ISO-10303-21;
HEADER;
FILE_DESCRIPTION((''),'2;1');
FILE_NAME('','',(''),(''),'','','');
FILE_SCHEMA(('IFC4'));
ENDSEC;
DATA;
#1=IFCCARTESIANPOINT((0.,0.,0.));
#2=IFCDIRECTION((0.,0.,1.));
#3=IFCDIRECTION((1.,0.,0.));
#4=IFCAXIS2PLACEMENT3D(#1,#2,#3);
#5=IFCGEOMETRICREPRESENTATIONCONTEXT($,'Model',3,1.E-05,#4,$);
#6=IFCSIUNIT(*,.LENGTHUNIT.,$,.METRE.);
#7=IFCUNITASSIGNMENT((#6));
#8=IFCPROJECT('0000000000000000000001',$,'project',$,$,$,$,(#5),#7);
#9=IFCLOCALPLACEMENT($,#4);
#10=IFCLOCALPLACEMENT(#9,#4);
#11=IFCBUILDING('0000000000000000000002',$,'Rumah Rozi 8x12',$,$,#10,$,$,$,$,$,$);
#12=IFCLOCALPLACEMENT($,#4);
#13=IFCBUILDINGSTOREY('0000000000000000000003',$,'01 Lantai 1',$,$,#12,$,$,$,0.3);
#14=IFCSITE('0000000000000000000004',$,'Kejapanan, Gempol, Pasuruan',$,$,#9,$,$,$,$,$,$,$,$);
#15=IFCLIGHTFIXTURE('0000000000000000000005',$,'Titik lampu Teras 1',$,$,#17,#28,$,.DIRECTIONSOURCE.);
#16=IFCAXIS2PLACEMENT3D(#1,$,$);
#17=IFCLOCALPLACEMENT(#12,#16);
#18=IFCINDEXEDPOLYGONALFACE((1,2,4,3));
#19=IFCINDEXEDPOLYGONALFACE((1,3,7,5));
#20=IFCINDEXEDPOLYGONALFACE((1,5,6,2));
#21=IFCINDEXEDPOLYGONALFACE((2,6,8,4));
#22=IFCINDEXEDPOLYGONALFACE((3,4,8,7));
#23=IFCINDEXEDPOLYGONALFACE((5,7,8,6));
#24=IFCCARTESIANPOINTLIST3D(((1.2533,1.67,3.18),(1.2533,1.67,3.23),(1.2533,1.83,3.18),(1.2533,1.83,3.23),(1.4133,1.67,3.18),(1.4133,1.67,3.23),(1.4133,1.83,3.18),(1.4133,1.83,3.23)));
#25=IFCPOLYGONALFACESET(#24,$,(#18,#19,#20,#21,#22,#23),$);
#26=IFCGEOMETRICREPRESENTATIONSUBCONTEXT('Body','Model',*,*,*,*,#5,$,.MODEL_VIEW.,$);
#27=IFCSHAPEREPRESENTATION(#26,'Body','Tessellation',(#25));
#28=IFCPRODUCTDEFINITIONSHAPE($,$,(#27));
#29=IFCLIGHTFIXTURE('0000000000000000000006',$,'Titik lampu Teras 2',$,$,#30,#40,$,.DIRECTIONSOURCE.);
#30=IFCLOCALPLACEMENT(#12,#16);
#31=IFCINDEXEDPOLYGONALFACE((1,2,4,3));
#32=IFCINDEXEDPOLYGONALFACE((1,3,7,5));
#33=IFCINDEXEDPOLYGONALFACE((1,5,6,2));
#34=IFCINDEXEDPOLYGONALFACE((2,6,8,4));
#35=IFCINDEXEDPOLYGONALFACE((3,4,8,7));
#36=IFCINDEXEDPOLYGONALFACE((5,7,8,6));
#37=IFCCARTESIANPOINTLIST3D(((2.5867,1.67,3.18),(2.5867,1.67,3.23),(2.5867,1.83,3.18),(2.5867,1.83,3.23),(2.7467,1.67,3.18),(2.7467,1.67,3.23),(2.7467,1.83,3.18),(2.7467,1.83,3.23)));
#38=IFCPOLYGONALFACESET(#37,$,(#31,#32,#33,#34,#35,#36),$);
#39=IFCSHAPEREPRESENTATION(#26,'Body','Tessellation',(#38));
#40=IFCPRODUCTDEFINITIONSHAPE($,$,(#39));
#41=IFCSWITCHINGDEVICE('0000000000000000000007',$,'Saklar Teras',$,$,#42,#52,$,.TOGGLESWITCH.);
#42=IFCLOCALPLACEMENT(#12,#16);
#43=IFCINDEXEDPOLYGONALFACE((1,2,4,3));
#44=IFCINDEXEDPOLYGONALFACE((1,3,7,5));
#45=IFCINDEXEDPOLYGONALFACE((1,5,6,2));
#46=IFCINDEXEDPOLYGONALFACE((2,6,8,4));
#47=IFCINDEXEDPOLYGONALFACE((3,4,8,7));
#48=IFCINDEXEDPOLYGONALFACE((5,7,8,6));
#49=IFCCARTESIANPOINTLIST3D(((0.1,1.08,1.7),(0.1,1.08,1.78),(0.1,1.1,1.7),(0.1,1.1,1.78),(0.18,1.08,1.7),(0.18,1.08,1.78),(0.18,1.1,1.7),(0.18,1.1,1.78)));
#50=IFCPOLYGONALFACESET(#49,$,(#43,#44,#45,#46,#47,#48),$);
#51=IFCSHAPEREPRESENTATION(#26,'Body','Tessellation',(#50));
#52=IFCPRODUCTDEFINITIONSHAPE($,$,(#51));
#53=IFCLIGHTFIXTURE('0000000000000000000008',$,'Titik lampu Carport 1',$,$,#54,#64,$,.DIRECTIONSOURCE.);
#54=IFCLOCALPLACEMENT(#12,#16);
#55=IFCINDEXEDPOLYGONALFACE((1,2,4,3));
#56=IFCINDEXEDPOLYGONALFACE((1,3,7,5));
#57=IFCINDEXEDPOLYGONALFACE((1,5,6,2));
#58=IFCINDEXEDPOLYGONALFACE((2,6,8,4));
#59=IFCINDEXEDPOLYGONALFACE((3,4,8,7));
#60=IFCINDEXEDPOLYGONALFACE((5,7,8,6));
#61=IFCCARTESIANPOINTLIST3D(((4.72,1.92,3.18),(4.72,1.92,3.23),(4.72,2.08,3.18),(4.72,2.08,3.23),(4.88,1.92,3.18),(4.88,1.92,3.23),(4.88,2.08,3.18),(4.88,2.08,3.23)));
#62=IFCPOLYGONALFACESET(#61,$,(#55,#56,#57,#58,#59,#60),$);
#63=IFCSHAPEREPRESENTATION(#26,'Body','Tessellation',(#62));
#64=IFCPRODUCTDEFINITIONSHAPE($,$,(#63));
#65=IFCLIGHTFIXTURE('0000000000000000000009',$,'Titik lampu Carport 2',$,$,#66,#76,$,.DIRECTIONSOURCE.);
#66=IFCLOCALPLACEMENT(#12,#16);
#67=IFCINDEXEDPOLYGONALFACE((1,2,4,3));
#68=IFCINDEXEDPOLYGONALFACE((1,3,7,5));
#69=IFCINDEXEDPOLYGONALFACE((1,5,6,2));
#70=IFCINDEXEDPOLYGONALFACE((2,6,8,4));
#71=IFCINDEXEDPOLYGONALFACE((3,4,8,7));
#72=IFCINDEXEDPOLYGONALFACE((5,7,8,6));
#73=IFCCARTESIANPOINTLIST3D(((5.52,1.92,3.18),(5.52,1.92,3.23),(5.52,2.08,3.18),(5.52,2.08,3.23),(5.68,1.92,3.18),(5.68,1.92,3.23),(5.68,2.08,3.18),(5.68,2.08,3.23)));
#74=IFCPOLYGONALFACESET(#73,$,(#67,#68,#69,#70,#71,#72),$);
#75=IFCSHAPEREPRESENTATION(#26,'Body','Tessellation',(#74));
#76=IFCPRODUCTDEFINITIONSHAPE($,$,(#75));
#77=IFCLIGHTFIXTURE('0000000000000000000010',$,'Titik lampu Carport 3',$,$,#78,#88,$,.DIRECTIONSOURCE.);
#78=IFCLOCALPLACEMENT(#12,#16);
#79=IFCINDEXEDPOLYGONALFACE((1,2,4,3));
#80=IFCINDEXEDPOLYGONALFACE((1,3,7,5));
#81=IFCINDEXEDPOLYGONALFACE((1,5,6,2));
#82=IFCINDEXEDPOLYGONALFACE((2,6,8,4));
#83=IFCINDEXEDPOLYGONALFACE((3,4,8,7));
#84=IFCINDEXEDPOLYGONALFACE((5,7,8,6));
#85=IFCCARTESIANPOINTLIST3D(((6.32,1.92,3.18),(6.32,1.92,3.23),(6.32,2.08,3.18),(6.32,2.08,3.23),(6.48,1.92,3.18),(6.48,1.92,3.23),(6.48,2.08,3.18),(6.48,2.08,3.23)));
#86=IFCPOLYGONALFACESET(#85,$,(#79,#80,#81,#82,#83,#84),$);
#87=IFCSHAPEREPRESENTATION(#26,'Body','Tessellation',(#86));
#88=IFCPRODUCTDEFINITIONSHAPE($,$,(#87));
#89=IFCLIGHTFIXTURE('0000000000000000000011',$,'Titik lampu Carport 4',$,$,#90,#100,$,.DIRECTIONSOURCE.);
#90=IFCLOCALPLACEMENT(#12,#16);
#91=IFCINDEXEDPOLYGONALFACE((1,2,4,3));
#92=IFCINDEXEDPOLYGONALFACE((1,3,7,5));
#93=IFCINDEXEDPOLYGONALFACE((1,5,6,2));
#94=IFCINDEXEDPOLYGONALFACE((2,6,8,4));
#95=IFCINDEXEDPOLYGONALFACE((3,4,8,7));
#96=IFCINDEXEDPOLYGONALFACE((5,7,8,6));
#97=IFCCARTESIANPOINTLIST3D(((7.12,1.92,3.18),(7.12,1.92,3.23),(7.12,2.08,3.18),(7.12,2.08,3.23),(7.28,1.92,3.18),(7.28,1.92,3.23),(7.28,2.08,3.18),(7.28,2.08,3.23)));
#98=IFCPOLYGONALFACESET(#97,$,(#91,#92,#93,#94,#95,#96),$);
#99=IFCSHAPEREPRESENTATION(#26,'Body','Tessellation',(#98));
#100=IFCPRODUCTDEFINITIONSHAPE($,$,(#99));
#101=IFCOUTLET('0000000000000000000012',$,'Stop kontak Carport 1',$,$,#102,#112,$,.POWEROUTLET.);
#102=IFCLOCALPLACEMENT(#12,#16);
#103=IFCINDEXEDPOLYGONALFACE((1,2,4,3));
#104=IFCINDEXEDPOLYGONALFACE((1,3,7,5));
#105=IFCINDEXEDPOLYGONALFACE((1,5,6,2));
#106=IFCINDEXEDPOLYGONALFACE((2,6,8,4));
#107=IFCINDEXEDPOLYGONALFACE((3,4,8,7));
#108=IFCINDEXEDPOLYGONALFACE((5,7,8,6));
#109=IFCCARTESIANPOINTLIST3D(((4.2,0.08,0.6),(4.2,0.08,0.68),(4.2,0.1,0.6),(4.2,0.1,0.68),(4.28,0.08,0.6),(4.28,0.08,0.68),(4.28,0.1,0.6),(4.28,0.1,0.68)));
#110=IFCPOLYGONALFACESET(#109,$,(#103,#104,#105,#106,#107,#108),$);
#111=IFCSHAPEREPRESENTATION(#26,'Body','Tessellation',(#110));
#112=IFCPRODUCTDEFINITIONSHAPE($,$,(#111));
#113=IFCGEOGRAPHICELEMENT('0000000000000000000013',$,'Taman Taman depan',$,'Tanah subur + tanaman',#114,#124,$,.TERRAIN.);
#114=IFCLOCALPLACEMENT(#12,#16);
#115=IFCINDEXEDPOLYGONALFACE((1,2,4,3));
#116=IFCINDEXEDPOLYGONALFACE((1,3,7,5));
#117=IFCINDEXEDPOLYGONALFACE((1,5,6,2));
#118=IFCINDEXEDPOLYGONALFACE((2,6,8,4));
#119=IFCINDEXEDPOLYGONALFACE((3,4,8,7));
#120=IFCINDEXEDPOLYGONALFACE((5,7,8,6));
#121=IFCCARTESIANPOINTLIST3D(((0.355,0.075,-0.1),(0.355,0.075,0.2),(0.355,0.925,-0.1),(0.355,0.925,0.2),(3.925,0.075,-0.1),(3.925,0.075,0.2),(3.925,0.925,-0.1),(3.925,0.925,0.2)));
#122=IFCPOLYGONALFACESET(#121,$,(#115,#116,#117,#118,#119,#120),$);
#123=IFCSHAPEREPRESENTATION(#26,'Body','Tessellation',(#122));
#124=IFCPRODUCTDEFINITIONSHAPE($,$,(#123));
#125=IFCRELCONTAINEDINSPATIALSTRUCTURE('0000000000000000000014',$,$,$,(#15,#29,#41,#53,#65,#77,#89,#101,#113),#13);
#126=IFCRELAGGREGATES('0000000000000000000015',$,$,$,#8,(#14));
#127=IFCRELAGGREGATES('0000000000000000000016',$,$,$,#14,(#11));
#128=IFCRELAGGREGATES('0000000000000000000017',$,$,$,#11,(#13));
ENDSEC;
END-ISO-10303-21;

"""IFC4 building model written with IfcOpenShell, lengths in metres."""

from ifc_helpers import new_model, si_unit, frame, origin_with_axes, place, context, subcontext, project, spatial, line, indexed_curve, outline, extrude, element, save


model = new_model("IFC4")

# Units and contexts
model_context = context("Model", 3, precision=1e-05, world=origin_with_axes())
body_context = subcontext(model_context, "Body", "Model", "MODEL_VIEW")
ifc_project = project(units=[si_unit("LENGTHUNIT", "METRE")], contexts=[model_context])

# Site, building, storey
site_placement = place(None, origin_with_axes())
site = spatial("IfcSite", under=ifc_project, at=site_placement, Name="Kejapanan, Gempol, Pasuruan")
building_placement = place(site_placement, origin_with_axes())
building = spatial("IfcBuilding", under=site, at=building_placement, Name="Rumah Rozi 8x12")
storey_placement = place(None, origin_with_axes())
storey = spatial("IfcBuildingStorey", under=building, at=storey_placement, Name="01 Lantai 1", Elevation=0.3)

# Light fixtures
light_fixture_1_placement = place(storey_placement, origin_with_axes())
element("IfcLightFixture", 1, at=light_fixture_1_placement, inside=storey, Name="Titik lampu Teras 1", PredefinedType="DIRECTIONSOURCE", context=body_context, shape_type="SweptSolid", body=[
    extrude(outline(indexed_curve([(1.2533, 1.67), (1.4133, 1.67), (1.4133, 1.83), (1.2533, 1.83)], segments=[line(1, 2, 3, 4, 1)])), frame((0.0, 0.0, 3.18), z_axis=(0.0, 0.0, 1.0), x_axis=(1.0, 0.0, 0.0)), (0.0, 0.0, 1.0), 0.05),
])
light_fixture_2_placement = place(storey_placement, origin_with_axes())
element("IfcLightFixture", 2, at=light_fixture_2_placement, inside=storey, Name="Titik lampu Teras 2", PredefinedType="DIRECTIONSOURCE", context=body_context, shape_type="SweptSolid", body=[
    extrude(outline(indexed_curve([(2.5867, 1.67), (2.7467, 1.67), (2.7467, 1.83), (2.5867, 1.83)], segments=[line(1, 2, 3, 4, 1)])), frame((0.0, 0.0, 3.18), z_axis=(0.0, 0.0, 1.0), x_axis=(1.0, 0.0, 0.0)), (0.0, 0.0, 1.0), 0.05),
])

# Switching device
switching_device_placement = place(storey_placement, origin_with_axes())
element("IfcSwitchingDevice", 3, at=switching_device_placement, inside=storey, Name="Saklar Teras", PredefinedType="TOGGLESWITCH", context=body_context, shape_type="SweptSolid", body=[
    extrude(outline(indexed_curve([(0.1, 1.08), (0.18, 1.08), (0.18, 1.1), (0.1, 1.1)], segments=[line(1, 2, 3, 4, 1)])), frame((0.0, 0.0, 1.7), z_axis=(0.0, 0.0, 1.0), x_axis=(1.0, 0.0, 0.0)), (0.0, 0.0, 1.0), 0.08),
])

# Light fixtures
light_fixture_3_placement = place(storey_placement, origin_with_axes())
element("IfcLightFixture", 4, at=light_fixture_3_placement, inside=storey, Name="Titik lampu Carport 1", PredefinedType="DIRECTIONSOURCE", context=body_context, shape_type="SweptSolid", body=[
    extrude(outline(indexed_curve([(4.72, 1.92), (4.88, 1.92), (4.88, 2.08), (4.72, 2.08)], segments=[line(1, 2, 3, 4, 1)])), frame((0.0, 0.0, 3.18), z_axis=(0.0, 0.0, 1.0), x_axis=(1.0, 0.0, 0.0)), (0.0, 0.0, 1.0), 0.05),
])
light_fixture_4_placement = place(storey_placement, origin_with_axes())
element("IfcLightFixture", 5, at=light_fixture_4_placement, inside=storey, Name="Titik lampu Carport 2", PredefinedType="DIRECTIONSOURCE", context=body_context, shape_type="SweptSolid", body=[
    extrude(outline(indexed_curve([(5.52, 1.92), (5.68, 1.92), (5.68, 2.08), (5.52, 2.08)], segments=[line(1, 2, 3, 4, 1)])), frame((0.0, 0.0, 3.18), z_axis=(0.0, 0.0, 1.0), x_axis=(1.0, 0.0, 0.0)), (0.0, 0.0, 1.0), 0.05),
])
light_fixture_5_placement = place(storey_placement, origin_with_axes())
element("IfcLightFixture", 6, at=light_fixture_5_placement, inside=storey, Name="Titik lampu Carport 3", PredefinedType="DIRECTIONSOURCE", context=body_context, shape_type="SweptSolid", body=[
    extrude(outline(indexed_curve([(6.32, 1.92), (6.48, 1.92), (6.48, 2.08), (6.32, 2.08)], segments=[line(1, 2, 3, 4, 1)])), frame((0.0, 0.0, 3.18), z_axis=(0.0, 0.0, 1.0), x_axis=(1.0, 0.0, 0.0)), (0.0, 0.0, 1.0), 0.05),
])
light_fixture_6_placement = place(storey_placement, origin_with_axes())
element("IfcLightFixture", 7, at=light_fixture_6_placement, inside=storey, Name="Titik lampu Carport 4", PredefinedType="DIRECTIONSOURCE", context=body_context, shape_type="SweptSolid", body=[
    extrude(outline(indexed_curve([(7.12, 1.92), (7.28, 1.92), (7.28, 2.08), (7.12, 2.08)], segments=[line(1, 2, 3, 4, 1)])), frame((0.0, 0.0, 3.18), z_axis=(0.0, 0.0, 1.0), x_axis=(1.0, 0.0, 0.0)), (0.0, 0.0, 1.0), 0.05),
])

# Outlet
outlet_placement = place(storey_placement, origin_with_axes())
element("IfcOutlet", 8, at=outlet_placement, inside=storey, Name="Stop kontak Carport 1", PredefinedType="POWEROUTLET", context=body_context, shape_type="SweptSolid", body=[
    extrude(outline(indexed_curve([(4.2, 0.08), (4.28, 0.08), (4.28, 0.1), (4.2, 0.1)], segments=[line(1, 2, 3, 4, 1)])), frame((0.0, 0.0, 0.6), z_axis=(0.0, 0.0, 1.0), x_axis=(1.0, 0.0, 0.0)), (0.0, 0.0, 1.0), 0.08),
])

# Geographic element
geographic_element_placement = place(storey_placement, origin_with_axes())
element("IfcGeographicElement", 9, at=geographic_element_placement, inside=storey, Name="Taman Taman depan", ObjectType="Tanah subur + tanaman", PredefinedType="TERRAIN", context=body_context, shape_type="SweptSolid", body=[
    extrude(outline(indexed_curve([(0.355, 0.075), (3.925, 0.075), (3.925, 0.925), (0.355, 0.925)], segments=[line(1, 2, 3, 4, 1)])), frame((0.0, 0.0, -0.1), z_axis=(0.0, 0.0, 1.0), x_axis=(1.0, 0.0, 0.0)), (0.0, 0.0, 1.0), 0.3),
])

save(model, "model.ifc")
